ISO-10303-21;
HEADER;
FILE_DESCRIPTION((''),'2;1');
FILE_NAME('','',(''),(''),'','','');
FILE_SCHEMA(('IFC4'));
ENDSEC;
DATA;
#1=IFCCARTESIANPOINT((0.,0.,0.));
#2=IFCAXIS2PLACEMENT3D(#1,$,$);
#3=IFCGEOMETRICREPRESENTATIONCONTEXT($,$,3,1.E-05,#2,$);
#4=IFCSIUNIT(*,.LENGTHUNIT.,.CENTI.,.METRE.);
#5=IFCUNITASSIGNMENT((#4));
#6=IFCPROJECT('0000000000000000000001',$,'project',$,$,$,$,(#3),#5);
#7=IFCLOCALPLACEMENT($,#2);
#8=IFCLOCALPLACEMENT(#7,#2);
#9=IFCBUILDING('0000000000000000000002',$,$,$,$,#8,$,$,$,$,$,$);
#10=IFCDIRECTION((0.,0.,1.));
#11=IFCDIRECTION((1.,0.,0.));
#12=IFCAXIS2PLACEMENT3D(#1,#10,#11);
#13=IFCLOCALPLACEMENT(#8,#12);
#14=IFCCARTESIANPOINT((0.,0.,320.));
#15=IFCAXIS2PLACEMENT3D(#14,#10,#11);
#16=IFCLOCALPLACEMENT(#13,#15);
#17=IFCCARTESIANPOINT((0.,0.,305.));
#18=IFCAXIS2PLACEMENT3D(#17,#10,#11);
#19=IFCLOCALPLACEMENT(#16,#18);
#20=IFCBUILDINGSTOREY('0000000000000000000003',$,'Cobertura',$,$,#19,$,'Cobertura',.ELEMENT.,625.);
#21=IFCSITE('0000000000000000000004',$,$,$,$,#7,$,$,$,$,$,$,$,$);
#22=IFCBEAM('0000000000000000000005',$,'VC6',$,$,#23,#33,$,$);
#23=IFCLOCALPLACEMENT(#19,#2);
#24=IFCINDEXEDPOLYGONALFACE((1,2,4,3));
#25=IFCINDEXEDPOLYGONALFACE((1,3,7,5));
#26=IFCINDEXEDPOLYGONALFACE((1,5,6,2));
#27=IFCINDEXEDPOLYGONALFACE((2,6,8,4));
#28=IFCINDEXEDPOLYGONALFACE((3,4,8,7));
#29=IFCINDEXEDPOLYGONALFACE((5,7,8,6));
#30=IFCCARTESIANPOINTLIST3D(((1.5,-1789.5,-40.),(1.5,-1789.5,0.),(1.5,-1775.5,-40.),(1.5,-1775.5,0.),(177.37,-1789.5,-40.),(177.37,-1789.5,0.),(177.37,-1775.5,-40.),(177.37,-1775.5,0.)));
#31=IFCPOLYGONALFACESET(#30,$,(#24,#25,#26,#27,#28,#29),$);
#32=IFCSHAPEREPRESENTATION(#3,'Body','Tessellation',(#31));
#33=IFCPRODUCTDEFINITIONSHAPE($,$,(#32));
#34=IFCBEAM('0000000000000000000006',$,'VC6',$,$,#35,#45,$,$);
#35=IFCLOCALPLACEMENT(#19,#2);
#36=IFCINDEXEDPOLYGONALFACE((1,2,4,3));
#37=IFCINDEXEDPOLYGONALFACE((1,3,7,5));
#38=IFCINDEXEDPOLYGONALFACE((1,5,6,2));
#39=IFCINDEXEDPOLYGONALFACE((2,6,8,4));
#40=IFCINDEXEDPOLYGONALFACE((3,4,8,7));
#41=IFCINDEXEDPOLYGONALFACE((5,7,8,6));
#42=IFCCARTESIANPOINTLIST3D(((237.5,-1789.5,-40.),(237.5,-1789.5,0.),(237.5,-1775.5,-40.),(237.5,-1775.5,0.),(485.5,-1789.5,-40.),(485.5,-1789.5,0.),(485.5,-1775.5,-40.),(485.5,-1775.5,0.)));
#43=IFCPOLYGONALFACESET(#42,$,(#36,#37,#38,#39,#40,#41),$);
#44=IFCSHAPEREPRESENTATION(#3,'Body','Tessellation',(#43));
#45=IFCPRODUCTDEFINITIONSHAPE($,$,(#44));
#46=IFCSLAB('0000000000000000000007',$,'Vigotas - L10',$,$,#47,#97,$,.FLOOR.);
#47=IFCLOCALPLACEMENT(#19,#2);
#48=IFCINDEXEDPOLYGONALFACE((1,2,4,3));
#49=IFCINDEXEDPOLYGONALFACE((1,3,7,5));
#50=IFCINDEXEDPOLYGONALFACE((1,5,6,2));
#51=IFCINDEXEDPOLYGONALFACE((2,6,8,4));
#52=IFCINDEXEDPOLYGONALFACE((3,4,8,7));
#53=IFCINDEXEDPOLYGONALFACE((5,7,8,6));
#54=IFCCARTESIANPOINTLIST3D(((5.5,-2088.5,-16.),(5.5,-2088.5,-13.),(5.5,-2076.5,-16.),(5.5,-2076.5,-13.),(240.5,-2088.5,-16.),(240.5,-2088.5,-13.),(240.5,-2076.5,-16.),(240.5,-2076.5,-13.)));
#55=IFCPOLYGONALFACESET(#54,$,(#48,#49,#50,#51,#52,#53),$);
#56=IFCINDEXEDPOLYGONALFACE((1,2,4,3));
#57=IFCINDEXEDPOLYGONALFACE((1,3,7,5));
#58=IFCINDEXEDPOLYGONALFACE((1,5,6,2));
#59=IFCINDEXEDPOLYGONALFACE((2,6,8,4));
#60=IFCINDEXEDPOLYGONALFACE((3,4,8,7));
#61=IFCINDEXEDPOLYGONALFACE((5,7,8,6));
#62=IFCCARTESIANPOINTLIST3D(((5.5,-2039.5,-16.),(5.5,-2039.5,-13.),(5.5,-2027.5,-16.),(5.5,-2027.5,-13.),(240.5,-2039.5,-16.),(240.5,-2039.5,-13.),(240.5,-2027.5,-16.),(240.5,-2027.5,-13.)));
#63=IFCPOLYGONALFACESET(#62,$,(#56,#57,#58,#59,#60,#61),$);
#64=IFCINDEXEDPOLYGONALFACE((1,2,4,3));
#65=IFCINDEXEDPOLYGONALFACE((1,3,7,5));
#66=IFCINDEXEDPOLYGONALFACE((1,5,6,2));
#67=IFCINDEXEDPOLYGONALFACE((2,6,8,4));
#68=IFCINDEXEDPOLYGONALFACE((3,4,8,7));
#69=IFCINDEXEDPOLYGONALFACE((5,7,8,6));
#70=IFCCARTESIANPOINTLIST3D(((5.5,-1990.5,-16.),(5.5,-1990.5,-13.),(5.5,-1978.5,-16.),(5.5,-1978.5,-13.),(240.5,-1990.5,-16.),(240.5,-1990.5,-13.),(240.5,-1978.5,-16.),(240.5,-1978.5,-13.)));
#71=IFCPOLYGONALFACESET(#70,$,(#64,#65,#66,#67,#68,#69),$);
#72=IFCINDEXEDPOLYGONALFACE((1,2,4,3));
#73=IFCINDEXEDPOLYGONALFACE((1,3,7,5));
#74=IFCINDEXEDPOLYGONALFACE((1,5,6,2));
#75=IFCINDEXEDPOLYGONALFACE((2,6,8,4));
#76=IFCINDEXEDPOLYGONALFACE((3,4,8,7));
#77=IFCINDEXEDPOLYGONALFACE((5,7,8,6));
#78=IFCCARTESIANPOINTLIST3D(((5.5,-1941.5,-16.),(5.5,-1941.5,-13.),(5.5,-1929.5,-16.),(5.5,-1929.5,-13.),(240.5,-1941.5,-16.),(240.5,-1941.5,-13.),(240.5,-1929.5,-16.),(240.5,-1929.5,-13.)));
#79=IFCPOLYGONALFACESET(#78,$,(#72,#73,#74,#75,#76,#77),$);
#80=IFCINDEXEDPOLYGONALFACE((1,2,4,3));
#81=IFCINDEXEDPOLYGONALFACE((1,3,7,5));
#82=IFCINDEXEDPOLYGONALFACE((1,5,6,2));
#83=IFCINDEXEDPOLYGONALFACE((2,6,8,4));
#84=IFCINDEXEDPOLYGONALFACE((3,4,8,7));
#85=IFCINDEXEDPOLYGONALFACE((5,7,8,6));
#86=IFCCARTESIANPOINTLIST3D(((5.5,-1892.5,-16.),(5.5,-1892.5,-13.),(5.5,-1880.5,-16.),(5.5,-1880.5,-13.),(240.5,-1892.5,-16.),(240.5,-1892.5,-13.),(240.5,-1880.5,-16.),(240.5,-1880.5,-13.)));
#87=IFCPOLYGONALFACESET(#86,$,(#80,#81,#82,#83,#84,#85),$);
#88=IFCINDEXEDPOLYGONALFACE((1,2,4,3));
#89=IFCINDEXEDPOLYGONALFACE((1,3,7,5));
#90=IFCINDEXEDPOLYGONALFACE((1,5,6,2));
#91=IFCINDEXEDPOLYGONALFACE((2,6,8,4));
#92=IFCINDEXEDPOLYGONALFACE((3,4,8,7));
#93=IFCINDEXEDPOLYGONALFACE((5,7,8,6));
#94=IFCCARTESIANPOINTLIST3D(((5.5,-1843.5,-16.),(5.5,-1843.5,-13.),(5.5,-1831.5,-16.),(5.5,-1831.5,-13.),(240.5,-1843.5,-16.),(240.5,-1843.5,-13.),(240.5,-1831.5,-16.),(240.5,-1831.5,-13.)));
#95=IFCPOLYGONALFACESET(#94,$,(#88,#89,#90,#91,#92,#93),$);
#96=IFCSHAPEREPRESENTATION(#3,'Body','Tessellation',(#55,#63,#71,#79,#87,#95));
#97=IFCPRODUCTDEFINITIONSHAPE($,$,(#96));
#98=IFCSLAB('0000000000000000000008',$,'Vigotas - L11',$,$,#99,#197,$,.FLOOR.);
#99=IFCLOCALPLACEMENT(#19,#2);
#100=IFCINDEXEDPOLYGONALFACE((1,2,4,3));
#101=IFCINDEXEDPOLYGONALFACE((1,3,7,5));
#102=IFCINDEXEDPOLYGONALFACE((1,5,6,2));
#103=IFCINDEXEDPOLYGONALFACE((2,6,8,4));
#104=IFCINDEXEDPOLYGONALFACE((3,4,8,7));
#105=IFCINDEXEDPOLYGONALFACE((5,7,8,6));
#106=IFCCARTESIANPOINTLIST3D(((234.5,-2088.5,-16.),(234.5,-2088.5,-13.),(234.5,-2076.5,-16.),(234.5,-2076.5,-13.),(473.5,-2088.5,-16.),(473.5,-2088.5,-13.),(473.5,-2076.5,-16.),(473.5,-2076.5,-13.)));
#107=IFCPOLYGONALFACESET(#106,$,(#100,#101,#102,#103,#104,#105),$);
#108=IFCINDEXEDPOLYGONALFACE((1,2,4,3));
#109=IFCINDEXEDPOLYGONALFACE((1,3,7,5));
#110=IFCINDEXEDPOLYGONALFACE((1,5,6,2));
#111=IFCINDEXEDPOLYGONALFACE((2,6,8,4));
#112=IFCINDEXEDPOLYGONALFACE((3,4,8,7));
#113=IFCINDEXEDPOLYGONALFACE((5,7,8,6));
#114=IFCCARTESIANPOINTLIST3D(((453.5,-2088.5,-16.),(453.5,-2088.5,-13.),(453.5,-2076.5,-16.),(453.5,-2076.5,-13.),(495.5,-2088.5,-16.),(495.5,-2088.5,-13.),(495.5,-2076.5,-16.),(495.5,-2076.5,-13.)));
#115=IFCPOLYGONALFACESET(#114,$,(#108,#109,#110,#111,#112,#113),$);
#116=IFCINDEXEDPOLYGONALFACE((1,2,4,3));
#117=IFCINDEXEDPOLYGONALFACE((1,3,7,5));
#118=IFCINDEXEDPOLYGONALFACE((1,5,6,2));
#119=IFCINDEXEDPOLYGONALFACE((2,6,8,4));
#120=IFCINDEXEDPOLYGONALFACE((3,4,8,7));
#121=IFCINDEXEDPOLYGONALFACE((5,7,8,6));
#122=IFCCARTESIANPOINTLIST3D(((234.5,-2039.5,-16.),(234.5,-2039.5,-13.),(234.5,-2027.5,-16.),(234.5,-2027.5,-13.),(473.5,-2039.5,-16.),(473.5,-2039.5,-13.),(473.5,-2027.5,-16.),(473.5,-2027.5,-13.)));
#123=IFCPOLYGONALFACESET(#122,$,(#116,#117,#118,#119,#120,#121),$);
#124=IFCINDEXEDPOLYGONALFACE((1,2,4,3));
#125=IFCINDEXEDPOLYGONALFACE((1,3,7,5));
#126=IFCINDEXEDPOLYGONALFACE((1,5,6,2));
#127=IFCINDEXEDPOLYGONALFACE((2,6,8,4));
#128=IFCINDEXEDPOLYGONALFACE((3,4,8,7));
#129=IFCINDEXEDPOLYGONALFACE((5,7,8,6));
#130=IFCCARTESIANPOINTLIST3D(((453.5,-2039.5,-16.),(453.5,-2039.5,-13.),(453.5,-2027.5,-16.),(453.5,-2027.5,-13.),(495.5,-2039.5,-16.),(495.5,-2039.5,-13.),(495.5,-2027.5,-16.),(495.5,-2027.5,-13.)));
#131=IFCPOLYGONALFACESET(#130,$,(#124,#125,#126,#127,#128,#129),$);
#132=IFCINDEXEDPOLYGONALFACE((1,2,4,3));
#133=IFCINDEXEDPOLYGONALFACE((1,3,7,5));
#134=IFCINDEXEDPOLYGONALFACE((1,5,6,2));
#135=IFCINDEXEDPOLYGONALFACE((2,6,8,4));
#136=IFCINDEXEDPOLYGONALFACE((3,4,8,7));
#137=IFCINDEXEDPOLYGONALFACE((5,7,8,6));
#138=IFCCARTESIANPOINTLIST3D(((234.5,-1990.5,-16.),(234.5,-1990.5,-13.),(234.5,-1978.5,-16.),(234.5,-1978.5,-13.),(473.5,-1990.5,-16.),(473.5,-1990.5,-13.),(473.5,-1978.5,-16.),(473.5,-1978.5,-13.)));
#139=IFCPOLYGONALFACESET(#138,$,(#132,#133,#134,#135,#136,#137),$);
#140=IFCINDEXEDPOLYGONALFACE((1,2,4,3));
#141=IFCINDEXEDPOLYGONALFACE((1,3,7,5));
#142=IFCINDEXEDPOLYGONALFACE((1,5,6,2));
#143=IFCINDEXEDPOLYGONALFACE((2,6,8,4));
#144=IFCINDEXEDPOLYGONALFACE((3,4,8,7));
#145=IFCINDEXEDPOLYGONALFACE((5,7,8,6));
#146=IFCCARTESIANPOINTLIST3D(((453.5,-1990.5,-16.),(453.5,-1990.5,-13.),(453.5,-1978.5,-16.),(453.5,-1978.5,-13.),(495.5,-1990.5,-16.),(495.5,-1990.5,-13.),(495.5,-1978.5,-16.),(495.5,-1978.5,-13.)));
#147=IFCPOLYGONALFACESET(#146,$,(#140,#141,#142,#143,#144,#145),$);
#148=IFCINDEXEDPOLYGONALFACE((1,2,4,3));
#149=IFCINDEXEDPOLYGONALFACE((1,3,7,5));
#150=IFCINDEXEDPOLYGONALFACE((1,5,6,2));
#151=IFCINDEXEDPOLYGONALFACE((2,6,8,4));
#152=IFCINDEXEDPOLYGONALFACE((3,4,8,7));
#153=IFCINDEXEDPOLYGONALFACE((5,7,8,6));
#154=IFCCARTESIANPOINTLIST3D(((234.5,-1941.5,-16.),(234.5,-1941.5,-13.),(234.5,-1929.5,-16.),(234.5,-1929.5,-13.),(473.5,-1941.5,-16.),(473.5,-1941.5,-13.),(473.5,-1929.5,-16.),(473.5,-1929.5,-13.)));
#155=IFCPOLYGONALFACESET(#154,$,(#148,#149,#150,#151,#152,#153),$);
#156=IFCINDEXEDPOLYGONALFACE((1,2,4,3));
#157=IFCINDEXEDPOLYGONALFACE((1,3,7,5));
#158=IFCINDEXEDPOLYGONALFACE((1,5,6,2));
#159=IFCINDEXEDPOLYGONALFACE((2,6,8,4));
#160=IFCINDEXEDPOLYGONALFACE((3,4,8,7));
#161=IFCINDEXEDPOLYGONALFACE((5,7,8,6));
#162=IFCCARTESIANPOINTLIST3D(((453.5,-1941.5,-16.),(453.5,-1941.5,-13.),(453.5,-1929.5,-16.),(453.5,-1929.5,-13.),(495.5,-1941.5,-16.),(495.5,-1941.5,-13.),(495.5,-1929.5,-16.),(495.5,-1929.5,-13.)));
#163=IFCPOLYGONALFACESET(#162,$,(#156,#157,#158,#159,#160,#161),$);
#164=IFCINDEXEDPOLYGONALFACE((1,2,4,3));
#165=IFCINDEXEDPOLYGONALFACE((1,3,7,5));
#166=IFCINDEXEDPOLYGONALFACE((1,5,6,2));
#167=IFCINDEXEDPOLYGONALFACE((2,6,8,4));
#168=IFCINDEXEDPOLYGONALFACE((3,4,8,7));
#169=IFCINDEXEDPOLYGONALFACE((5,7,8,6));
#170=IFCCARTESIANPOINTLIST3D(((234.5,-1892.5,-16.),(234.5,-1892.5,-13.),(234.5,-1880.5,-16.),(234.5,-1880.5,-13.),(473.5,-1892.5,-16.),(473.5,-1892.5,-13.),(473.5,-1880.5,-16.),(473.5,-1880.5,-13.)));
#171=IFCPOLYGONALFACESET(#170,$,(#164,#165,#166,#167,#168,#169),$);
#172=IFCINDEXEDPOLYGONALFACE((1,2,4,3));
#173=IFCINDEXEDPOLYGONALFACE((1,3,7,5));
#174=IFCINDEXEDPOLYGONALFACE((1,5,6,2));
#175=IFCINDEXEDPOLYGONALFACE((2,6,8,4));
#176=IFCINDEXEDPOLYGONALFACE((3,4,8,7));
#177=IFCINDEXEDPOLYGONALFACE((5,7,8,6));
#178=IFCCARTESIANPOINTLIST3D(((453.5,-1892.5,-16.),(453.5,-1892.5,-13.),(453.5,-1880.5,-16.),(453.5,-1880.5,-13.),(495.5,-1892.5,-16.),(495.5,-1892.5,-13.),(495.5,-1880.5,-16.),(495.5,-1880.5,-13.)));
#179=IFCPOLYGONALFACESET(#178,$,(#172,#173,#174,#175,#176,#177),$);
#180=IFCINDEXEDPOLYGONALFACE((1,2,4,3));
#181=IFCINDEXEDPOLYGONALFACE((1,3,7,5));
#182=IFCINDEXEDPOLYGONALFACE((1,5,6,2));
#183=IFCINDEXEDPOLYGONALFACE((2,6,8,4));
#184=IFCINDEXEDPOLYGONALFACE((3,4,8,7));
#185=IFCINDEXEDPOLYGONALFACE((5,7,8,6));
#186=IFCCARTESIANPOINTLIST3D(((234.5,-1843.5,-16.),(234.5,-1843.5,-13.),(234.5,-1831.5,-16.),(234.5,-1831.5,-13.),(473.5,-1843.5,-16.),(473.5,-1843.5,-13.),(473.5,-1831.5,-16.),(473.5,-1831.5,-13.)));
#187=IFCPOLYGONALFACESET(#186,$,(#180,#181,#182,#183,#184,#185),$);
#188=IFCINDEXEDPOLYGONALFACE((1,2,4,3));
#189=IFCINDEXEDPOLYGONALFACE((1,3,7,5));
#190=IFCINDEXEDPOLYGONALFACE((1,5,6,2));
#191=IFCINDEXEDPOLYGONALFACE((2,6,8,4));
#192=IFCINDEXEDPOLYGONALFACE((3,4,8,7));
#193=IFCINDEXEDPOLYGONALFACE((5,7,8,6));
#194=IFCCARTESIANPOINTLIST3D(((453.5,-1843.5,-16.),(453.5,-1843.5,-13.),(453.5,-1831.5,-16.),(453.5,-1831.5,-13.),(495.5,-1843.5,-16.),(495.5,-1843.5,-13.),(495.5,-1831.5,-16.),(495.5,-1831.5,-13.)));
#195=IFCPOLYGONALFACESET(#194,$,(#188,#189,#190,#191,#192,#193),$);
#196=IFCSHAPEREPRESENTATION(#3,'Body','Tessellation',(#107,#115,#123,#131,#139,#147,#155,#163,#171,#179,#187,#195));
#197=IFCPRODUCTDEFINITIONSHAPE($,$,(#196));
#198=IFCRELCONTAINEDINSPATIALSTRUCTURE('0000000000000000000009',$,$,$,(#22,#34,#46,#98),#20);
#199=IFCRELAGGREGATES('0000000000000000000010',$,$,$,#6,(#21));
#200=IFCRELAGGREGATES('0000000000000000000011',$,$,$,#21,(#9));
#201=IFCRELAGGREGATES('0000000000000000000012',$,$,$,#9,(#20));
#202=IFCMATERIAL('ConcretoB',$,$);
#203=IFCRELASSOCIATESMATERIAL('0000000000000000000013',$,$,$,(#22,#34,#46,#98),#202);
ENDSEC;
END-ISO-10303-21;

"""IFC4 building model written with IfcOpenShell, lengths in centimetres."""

from ifc_helpers import new_model, si_unit, frame, origin, origin_with_axes, place, context, project, spatial, polyline, outline, extrude, material, element, save


model = new_model("IFC4")

# Units and contexts
context_of_model = context(None, 3, precision=1e-05, world=origin())
ifc_project = project(units=[si_unit("LENGTHUNIT", "METRE", prefix="CENTI")], contexts=[context_of_model])

# Site, building, storey
site_placement = place(None, origin())
site = spatial("IfcSite", under=ifc_project, at=site_placement)
building_placement = place(site_placement, origin())
building = spatial("IfcBuilding", under=site, at=building_placement)
placement_1 = place(building_placement, origin_with_axes())
placement_2 = place(placement_1, frame((0.0, 0.0, 320.0), z_axis=(0.0, 0.0, 1.0), x_axis=(1.0, 0.0, 0.0)))
storey_placement = place(placement_2, frame((0.0, 0.0, 305.0), z_axis=(0.0, 0.0, 1.0), x_axis=(1.0, 0.0, 0.0)))
storey = spatial("IfcBuildingStorey", under=building, at=storey_placement, Name="Cobertura", LongName="Cobertura", CompositionType="ELEMENT", Elevation=625.0)

# Shared definitions
ifc_material = material(Name="ConcretoB")

# Beams
beam_1_placement = place(storey_placement, frame((89.44, -1782.5, 0.0), z_axis=(0.0, 0.0, 1.0), x_axis=(1.0, 0.0, 0.0)))
element("IfcBeam", 1, at=beam_1_placement, inside=storey, material=ifc_material, Name="VC6", context=context_of_model, shape_type="SolidModel", body=[
    extrude(outline(polyline([(-7.0, -20.0), (7.0, -20.0), (7.0, 20.0), (-7.0, 20.0), (-7.0, -20.0)])), frame((-87.94, 0.0, -20.0), z_axis=(1.0, 0.0, 0.0), x_axis=(0.0, -1.0, 0.0)), (0.0, 0.0, 1.0), 175.87),
])
beam_2_placement = place(storey_placement, frame((361.5, -1782.5, 0.0), z_axis=(0.0, 0.0, 1.0), x_axis=(1.0, 0.0, 0.0)))
element("IfcBeam", 2, at=beam_2_placement, inside=storey, material=ifc_material, Name="VC6", context=context_of_model, shape_type="SolidModel", body=[
    extrude(outline(polyline([(-7.0, -20.0), (7.0, -20.0), (7.0, 20.0), (-7.0, 20.0), (-7.0, -20.0)])), frame((-124.0, 0.0, -20.0), z_axis=(1.0, 0.0, 0.0), x_axis=(0.0, -1.0, 0.0)), (0.0, 0.0, 1.0), 248.0),
])

# Slabs
slab_1_placement = place(storey_placement, frame((123.0, -1960.0, -13.0), z_axis=(0.0, 0.0, 1.0), x_axis=(1.0, 0.0, 0.0)))
element("IfcSlab", 3, at=slab_1_placement, inside=storey, material=ifc_material, Name="Vigotas - L10", PredefinedType="FLOOR", context=context_of_model, shape_type="SolidModel", body=[
    extrude(outline(polyline([(6.0, 1.5), (-6.0, 1.5), (-6.0, -1.5), (6.0, -1.5), (6.0, 1.5), (6.0, 1.5)])), frame((-117.5, -122.5, -1.5), z_axis=(1.0, 0.0, 0.0), x_axis=(0.0, -1.0, 0.0)), (0.0, 0.0, 1.0), 235.0),
    extrude(outline(polyline([(6.0, 1.5), (-6.0, 1.5), (-6.0, -1.5), (6.0, -1.5), (6.0, 1.5), (6.0, 1.5)])), frame((-117.5, -73.5, -1.5), z_axis=(1.0, 0.0, 0.0), x_axis=(0.0, -1.0, 0.0)), (0.0, 0.0, 1.0), 235.0),
    extrude(outline(polyline([(6.0, 1.5), (-6.0, 1.5), (-6.0, -1.5), (6.0, -1.5), (6.0, 1.5), (6.0, 1.5)])), frame((-117.5, -24.5, -1.5), z_axis=(1.0, 0.0, 0.0), x_axis=(0.0, -1.0, 0.0)), (0.0, 0.0, 1.0), 235.0),
    extrude(outline(polyline([(6.0, 1.5), (-6.0, 1.5), (-6.0, -1.5), (6.0, -1.5), (6.0, 1.5), (6.0, 1.5)])), frame((-117.5, 24.5, -1.5), z_axis=(1.0, 0.0, 0.0), x_axis=(0.0, -1.0, 0.0)), (0.0, 0.0, 1.0), 235.0),
    extrude(outline(polyline([(6.0, 1.5), (-6.0, 1.5), (-6.0, -1.5), (6.0, -1.5), (6.0, 1.5), (6.0, 1.5)])), frame((-117.5, 73.5, -1.5), z_axis=(1.0, 0.0, 0.0), x_axis=(0.0, -1.0, 0.0)), (0.0, 0.0, 1.0), 235.0),
    extrude(outline(polyline([(6.0, 1.5), (-6.0, 1.5), (-6.0, -1.5), (6.0, -1.5), (6.0, 1.5), (6.0, 1.5)])), frame((-117.5, 122.5, -1.5), z_axis=(1.0, 0.0, 0.0), x_axis=(0.0, -1.0, 0.0)), (0.0, 0.0, 1.0), 235.0),
])
slab_2_placement = place(storey_placement, frame((365.0, -1960.0, -13.0), z_axis=(0.0, 0.0, 1.0), x_axis=(1.0, 0.0, 0.0)))
element("IfcSlab", 4, at=slab_2_placement, inside=storey, material=ifc_material, Name="Vigotas - L11", PredefinedType="FLOOR", context=context_of_model, shape_type="SolidModel", body=[
    extrude(outline(polyline([(6.0, 1.5), (-6.0, 1.5), (-6.0, -1.5), (6.0, -1.5), (6.0, 1.5), (6.0, 1.5)])), frame((-130.5, -122.5, -1.5), z_axis=(1.0, 0.0, 0.0), x_axis=(0.0, -1.0, 0.0)), (0.0, 0.0, 1.0), 239.0),
    extrude(outline(polyline([(6.0, 1.5), (-6.0, 1.5), (-6.0, -1.5), (6.0, -1.5), (6.0, 1.5), (6.0, 1.5)])), frame((88.5, -122.5, -1.5), z_axis=(1.0, 0.0, 0.0), x_axis=(0.0, -1.0, 0.0)), (0.0, 0.0, 1.0), 42.0),
    extrude(outline(polyline([(6.0, 1.5), (-6.0, 1.5), (-6.0, -1.5), (6.0, -1.5), (6.0, 1.5), (6.0, 1.5)])), frame((-130.5, -73.5, -1.5), z_axis=(1.0, 0.0, 0.0), x_axis=(0.0, -1.0, 0.0)), (0.0, 0.0, 1.0), 239.0),
    extrude(outline(polyline([(6.0, 1.5), (-6.0, 1.5), (-6.0, -1.5), (6.0, -1.5), (6.0, 1.5), (6.0, 1.5)])), frame((88.5, -73.5, -1.5), z_axis=(1.0, 0.0, 0.0), x_axis=(0.0, -1.0, 0.0)), (0.0, 0.0, 1.0), 42.0),
    extrude(outline(polyline([(6.0, 1.5), (-6.0, 1.5), (-6.0, -1.5), (6.0, -1.5), (6.0, 1.5), (6.0, 1.5)])), frame((-130.5, -24.5, -1.5), z_axis=(1.0, 0.0, 0.0), x_axis=(0.0, -1.0, 0.0)), (0.0, 0.0, 1.0), 239.0),
    extrude(outline(polyline([(6.0, 1.5), (-6.0, 1.5), (-6.0, -1.5), (6.0, -1.5), (6.0, 1.5), (6.0, 1.5)])), frame((88.5, -24.5, -1.5), z_axis=(1.0, 0.0, 0.0), x_axis=(0.0, -1.0, 0.0)), (0.0, 0.0, 1.0), 42.0),
    extrude(outline(polyline([(6.0, 1.5), (-6.0, 1.5), (-6.0, -1.5), (6.0, -1.5), (6.0, 1.5), (6.0, 1.5)])), frame((-130.5, 24.5, -1.5), z_axis=(1.0, 0.0, 0.0), x_axis=(0.0, -1.0, 0.0)), (0.0, 0.0, 1.0), 239.0),
    extrude(outline(polyline([(6.0, 1.5), (-6.0, 1.5), (-6.0, -1.5), (6.0, -1.5), (6.0, 1.5), (6.0, 1.5)])), frame((88.5, 24.5, -1.5), z_axis=(1.0, 0.0, 0.0), x_axis=(0.0, -1.0, 0.0)), (0.0, 0.0, 1.0), 42.0),
    extrude(outline(polyline([(6.0, 1.5), (-6.0, 1.5), (-6.0, -1.5), (6.0, -1.5), (6.0, 1.5), (6.0, 1.5)])), frame((-130.5, 73.5, -1.5), z_axis=(1.0, 0.0, 0.0), x_axis=(0.0, -1.0, 0.0)), (0.0, 0.0, 1.0), 239.0),
    extrude(outline(polyline([(6.0, 1.5), (-6.0, 1.5), (-6.0, -1.5), (6.0, -1.5), (6.0, 1.5), (6.0, 1.5)])), frame((88.5, 73.5, -1.5), z_axis=(1.0, 0.0, 0.0), x_axis=(0.0, -1.0, 0.0)), (0.0, 0.0, 1.0), 42.0),
    extrude(outline(polyline([(6.0, 1.5), (-6.0, 1.5), (-6.0, -1.5), (6.0, -1.5), (6.0, 1.5), (6.0, 1.5)])), frame((-130.5, 122.5, -1.5), z_axis=(1.0, 0.0, 0.0), x_axis=(0.0, -1.0, 0.0)), (0.0, 0.0, 1.0), 239.0),
    extrude(outline(polyline([(6.0, 1.5), (-6.0, 1.5), (-6.0, -1.5), (6.0, -1.5), (6.0, 1.5), (6.0, 1.5)])), frame((88.5, 122.5, -1.5), z_axis=(1.0, 0.0, 0.0), x_axis=(0.0, -1.0, 0.0)), (0.0, 0.0, 1.0), 42.0),
])

save(model, "model.ifc")
